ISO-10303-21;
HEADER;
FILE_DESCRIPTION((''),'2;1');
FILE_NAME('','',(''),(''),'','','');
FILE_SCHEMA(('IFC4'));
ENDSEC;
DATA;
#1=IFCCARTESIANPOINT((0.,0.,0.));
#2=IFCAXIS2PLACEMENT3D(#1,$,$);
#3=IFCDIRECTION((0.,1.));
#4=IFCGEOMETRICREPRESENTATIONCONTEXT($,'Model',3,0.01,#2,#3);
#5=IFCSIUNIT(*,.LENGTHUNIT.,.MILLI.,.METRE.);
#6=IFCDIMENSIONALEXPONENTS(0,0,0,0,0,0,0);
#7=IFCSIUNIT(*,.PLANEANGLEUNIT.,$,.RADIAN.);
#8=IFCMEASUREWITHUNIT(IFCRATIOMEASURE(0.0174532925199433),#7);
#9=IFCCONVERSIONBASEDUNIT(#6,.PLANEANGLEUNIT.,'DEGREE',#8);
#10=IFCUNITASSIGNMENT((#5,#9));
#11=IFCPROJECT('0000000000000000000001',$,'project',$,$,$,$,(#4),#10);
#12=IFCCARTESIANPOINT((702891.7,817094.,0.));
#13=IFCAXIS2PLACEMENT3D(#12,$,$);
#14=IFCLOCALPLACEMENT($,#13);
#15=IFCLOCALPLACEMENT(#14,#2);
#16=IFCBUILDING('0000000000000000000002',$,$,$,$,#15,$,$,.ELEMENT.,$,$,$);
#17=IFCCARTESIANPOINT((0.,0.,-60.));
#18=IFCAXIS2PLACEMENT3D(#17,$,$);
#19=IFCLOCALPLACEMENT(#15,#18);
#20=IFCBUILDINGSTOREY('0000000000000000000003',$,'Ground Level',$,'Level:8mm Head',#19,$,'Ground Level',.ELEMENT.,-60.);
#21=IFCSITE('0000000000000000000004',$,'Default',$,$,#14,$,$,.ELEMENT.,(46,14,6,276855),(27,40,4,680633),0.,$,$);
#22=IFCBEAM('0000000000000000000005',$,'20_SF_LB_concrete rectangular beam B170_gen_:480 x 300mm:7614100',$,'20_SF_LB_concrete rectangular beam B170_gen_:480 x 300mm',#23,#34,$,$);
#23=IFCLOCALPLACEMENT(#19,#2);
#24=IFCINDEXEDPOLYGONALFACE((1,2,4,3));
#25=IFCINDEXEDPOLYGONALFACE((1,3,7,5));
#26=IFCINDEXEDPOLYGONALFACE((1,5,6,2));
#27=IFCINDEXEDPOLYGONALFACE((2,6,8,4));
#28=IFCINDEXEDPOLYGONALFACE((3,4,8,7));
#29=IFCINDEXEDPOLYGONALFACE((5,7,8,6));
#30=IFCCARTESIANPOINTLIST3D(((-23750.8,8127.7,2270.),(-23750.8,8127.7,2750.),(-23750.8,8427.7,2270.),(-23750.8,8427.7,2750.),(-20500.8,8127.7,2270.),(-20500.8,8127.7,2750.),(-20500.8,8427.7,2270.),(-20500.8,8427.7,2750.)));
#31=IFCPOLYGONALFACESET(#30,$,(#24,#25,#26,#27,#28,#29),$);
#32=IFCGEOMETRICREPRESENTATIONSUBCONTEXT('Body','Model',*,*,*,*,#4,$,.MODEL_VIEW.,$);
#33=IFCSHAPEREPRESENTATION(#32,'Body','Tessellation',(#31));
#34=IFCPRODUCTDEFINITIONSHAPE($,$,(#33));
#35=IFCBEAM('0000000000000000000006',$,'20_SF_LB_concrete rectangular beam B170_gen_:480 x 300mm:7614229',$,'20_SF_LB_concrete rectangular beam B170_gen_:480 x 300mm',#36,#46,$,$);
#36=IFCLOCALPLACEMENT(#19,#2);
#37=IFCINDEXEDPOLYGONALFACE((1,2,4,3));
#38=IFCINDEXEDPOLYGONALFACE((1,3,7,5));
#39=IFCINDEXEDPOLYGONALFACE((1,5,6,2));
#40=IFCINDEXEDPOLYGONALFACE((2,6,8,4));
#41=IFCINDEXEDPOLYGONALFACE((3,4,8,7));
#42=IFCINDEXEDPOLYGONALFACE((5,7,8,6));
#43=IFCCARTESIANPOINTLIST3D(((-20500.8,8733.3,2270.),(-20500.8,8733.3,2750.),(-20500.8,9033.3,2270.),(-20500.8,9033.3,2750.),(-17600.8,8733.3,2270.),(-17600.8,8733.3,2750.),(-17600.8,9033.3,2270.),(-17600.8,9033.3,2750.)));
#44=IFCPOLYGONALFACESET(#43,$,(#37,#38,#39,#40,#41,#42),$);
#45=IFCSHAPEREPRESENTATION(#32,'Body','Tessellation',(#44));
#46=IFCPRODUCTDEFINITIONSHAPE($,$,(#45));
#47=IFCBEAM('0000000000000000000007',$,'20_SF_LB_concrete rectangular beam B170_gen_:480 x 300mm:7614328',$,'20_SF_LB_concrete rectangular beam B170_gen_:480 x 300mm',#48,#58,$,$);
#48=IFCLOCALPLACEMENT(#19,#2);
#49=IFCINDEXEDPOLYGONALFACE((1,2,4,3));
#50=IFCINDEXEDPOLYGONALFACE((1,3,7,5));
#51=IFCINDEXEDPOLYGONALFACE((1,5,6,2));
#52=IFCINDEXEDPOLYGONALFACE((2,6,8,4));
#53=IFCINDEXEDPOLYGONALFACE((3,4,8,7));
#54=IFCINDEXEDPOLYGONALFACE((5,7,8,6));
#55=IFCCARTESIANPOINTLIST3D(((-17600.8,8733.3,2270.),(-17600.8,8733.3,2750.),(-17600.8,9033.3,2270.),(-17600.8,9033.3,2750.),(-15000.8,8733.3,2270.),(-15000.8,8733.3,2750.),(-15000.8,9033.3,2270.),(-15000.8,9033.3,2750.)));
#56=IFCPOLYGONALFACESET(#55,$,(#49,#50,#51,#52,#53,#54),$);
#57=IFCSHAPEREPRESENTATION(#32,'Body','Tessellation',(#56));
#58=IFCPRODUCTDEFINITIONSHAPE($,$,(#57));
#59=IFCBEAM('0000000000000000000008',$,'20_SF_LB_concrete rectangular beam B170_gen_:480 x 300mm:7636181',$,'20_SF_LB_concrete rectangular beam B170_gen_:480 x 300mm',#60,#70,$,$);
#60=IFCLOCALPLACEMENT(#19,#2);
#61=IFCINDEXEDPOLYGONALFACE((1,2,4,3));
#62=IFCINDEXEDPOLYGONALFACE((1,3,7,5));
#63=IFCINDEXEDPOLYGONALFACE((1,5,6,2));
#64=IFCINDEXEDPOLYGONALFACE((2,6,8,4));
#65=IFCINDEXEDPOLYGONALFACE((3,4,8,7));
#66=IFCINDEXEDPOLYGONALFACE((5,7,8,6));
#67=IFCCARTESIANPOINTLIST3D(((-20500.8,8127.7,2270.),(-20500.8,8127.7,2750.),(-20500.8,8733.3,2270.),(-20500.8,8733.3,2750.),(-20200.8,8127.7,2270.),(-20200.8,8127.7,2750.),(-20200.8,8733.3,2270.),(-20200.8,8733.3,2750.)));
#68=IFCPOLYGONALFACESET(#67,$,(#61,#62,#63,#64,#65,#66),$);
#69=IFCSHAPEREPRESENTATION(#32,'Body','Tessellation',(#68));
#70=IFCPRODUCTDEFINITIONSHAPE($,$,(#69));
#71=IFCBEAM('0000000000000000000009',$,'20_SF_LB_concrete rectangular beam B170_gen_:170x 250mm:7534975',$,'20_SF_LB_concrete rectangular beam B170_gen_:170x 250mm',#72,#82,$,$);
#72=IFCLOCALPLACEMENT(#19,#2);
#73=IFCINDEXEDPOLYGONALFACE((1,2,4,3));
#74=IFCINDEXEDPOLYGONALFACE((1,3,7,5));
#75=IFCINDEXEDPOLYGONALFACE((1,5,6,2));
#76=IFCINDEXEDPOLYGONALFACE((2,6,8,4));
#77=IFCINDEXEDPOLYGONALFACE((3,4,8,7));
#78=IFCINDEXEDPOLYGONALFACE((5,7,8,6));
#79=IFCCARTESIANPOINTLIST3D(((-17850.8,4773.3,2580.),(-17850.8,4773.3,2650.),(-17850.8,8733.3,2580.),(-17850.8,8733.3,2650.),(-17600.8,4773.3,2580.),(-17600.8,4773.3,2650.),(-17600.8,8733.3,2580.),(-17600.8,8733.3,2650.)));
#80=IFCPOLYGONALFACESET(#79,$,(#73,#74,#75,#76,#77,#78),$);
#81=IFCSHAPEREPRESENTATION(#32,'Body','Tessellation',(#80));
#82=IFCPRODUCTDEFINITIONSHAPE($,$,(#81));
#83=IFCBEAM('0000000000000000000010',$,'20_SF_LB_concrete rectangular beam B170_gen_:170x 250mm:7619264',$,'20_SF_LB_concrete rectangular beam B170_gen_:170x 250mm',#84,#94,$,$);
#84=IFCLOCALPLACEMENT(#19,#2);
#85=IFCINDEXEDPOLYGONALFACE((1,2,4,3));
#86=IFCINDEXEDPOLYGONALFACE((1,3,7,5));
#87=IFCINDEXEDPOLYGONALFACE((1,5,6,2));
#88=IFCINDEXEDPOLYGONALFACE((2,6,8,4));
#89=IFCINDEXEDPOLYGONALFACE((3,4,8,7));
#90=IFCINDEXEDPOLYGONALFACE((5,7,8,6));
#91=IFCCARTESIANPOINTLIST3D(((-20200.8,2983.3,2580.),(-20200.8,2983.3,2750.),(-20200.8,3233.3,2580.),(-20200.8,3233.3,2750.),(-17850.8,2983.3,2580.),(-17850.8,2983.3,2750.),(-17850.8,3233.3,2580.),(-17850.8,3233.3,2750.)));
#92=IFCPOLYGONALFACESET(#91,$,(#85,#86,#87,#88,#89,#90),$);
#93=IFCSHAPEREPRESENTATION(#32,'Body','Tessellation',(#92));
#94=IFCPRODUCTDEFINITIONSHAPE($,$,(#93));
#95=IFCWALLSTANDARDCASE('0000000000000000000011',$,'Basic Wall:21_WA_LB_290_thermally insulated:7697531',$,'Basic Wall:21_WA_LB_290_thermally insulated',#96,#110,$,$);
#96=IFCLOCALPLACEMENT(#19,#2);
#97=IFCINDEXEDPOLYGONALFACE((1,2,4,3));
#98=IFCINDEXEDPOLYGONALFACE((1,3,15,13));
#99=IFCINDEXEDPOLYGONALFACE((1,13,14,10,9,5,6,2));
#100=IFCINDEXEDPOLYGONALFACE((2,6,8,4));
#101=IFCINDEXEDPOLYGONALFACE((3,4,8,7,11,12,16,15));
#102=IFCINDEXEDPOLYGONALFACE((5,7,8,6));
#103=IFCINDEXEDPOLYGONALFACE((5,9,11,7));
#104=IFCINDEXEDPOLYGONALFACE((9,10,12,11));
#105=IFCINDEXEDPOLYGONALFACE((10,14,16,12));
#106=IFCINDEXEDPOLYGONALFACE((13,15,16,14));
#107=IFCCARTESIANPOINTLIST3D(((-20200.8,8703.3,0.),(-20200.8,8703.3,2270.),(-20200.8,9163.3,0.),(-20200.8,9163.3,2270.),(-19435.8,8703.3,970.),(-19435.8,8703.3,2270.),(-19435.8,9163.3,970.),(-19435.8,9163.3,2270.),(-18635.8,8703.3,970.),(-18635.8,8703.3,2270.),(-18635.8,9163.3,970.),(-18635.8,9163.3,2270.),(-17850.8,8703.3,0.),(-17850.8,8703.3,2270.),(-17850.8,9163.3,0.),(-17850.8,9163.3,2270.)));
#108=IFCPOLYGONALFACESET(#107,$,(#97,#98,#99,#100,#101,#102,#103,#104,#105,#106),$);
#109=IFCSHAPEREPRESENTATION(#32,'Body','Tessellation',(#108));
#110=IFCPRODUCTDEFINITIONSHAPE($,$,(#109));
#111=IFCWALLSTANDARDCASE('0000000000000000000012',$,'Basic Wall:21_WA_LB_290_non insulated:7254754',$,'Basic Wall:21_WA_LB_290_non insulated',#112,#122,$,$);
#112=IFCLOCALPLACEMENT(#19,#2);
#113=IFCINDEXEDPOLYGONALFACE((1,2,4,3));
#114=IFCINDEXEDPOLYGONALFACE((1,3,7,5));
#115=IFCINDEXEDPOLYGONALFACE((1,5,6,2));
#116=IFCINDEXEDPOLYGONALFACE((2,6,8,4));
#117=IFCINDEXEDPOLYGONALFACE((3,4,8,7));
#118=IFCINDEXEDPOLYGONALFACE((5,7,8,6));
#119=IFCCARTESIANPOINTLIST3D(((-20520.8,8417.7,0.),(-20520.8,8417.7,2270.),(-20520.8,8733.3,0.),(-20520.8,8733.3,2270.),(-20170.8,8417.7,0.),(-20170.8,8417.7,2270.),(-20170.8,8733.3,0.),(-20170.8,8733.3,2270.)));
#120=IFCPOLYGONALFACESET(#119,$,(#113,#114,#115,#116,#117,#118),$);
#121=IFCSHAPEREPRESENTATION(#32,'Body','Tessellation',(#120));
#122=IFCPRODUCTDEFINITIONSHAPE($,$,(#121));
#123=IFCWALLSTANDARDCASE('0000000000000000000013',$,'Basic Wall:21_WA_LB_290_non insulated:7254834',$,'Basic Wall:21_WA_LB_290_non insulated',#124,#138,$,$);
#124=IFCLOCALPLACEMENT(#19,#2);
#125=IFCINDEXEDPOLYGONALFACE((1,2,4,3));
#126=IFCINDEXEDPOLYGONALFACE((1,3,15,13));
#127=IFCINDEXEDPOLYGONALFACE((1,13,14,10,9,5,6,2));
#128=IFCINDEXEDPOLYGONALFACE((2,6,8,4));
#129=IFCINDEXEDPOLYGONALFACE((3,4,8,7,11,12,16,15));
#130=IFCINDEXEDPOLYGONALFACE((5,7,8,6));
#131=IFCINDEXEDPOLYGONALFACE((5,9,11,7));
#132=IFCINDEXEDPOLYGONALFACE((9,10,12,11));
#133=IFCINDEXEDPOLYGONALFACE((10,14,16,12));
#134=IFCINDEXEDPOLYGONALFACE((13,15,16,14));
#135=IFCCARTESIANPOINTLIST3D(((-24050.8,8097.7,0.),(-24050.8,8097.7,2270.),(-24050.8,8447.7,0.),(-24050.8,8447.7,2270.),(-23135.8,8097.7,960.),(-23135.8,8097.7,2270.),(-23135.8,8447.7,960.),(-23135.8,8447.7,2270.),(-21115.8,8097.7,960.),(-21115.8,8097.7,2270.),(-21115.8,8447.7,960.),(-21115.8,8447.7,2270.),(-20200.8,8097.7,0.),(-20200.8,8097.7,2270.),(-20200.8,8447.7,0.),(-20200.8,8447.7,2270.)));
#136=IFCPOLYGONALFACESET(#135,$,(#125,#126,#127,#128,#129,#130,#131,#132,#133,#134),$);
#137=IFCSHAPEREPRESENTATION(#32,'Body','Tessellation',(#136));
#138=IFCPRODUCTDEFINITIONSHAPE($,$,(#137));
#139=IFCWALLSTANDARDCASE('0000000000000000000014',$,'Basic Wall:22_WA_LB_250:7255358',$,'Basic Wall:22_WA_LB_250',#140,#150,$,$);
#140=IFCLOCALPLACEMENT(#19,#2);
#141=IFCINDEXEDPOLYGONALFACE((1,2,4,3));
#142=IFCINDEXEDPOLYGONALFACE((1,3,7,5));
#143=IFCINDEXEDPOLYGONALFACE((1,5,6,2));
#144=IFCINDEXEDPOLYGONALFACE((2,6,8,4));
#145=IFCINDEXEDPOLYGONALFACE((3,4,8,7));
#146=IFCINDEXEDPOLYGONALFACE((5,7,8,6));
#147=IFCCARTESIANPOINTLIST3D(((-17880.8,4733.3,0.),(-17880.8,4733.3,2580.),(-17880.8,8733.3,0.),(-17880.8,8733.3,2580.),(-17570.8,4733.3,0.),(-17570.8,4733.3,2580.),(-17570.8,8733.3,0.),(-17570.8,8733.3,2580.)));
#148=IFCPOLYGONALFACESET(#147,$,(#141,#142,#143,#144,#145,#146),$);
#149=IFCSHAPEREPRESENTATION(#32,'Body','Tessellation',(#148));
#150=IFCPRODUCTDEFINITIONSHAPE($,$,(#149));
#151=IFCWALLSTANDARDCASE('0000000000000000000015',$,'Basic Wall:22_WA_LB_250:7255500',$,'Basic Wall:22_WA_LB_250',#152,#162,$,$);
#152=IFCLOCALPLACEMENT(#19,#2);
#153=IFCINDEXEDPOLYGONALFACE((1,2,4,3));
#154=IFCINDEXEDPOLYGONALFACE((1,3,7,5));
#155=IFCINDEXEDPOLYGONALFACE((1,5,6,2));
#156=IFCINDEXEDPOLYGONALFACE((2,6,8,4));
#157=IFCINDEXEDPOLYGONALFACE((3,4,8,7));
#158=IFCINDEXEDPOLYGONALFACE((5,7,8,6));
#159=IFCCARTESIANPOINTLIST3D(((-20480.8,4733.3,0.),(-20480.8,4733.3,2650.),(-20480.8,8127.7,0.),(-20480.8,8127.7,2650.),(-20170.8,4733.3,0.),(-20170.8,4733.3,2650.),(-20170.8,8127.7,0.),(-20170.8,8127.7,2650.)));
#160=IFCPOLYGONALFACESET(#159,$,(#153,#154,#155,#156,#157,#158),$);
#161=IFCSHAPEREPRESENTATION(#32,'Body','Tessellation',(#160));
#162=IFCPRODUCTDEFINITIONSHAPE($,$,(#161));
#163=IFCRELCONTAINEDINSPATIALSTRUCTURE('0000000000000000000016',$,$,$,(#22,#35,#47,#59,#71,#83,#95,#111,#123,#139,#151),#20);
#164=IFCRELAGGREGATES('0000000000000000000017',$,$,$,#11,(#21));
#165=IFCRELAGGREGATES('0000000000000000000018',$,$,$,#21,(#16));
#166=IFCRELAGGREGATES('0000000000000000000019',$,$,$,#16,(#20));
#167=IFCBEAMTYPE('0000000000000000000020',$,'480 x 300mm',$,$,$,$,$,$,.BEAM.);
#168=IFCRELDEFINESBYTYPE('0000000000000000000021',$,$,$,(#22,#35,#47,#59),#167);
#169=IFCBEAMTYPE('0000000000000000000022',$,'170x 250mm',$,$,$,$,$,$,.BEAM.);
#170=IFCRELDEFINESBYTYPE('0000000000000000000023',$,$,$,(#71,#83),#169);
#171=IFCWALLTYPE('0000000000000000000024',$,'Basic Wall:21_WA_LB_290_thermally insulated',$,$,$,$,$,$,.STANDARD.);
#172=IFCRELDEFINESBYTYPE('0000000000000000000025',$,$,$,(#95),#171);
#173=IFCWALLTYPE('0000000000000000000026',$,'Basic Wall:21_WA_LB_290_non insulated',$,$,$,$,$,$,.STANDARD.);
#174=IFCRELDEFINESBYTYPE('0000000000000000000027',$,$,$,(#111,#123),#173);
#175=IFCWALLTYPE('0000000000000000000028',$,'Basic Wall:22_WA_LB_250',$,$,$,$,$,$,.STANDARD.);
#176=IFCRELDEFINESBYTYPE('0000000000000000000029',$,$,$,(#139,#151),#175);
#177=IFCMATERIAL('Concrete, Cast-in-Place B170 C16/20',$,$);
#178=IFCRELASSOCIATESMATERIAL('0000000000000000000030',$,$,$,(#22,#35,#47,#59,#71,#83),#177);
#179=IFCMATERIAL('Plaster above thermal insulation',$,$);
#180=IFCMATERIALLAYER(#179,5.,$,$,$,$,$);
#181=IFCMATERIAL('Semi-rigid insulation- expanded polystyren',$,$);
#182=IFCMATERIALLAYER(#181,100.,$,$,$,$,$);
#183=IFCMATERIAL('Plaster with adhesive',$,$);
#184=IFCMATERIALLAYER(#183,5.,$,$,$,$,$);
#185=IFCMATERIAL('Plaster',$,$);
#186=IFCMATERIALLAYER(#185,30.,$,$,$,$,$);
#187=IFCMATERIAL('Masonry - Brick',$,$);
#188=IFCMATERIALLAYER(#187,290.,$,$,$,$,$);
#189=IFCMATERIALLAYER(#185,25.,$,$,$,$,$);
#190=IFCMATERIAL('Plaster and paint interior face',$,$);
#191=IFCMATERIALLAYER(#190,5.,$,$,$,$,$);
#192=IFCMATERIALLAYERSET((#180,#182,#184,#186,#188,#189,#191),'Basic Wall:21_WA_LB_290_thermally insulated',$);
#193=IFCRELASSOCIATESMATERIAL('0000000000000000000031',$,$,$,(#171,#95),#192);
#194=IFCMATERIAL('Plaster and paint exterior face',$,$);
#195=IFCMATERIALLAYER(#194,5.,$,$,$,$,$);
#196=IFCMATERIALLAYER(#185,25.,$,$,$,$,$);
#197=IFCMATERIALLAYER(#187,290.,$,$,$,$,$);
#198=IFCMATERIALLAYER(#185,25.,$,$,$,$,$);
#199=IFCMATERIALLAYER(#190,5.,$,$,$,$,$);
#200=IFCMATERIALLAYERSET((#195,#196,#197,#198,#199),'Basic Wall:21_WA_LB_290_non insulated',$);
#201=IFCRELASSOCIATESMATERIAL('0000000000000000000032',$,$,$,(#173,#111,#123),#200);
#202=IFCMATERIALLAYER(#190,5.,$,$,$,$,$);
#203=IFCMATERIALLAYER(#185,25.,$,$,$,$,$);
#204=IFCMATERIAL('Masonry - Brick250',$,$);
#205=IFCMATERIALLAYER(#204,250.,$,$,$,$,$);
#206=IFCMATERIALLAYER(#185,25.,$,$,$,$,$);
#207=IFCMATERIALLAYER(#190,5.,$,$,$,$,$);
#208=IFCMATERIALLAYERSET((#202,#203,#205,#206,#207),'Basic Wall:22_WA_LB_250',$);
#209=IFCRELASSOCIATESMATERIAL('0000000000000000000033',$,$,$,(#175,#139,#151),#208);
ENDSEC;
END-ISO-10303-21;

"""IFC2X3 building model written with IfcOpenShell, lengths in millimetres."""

from ifc_helpers import new_model, entity, si_unit, converted_unit, direction, frame, frame_2d, origin, origin_2d_with_axis, place, context, subcontext, project, spatial, rectangle, extrude, material, layer, layer_set, layer_usage, type_object, element, save


model = new_model("IFC2X3")

# Units and contexts
model_context = context("Model", 3, precision=0.01, world=origin(), true_north=direction((0.0, 1.0)))
body_context = subcontext(model_context, "Body", "Model", "MODEL_VIEW")
ifc_project = project(units=[si_unit("LENGTHUNIT", "METRE", prefix="MILLI"), converted_unit("PLANEANGLEUNIT", "DEGREE", entity("IfcRatioMeasure", 0.0174532925199433), si_unit("PLANEANGLEUNIT", "RADIAN"), dimensions=[0, 0, 0, 0, 0, 0, 0])], contexts=[model_context])

# Site, building, storey
site_placement = place(None, frame((702891.7, 817094.0, 0.0)))
site = spatial("IfcSite", under=ifc_project, at=site_placement, Name="Default", CompositionType="ELEMENT", RefLatitude=(46, 14, 6, 276855), RefLongitude=(27, 40, 4, 680633), RefElevation=0.0)
building_placement = place(site_placement, origin())
building = spatial("IfcBuilding", under=site, at=building_placement, CompositionType="ELEMENT")
storey_placement = place(building_placement, frame((0.0, 0.0, -60.0)))
storey = spatial("IfcBuildingStorey", under=building, at=storey_placement, Name="Ground Level", ObjectType="Level:8mm Head", LongName="Ground Level", CompositionType="ELEMENT", Elevation=-60.0)

# Beams
ifc_material_1 = material(Name="Concrete, Cast-in-Place B170 C16/20")
beam_type_1 = type_object("IfcBeamType", Name="480 x 300mm", PredefinedType="BEAM")
beam_1_placement = place(storey_placement, frame((-23750.8, 8277.7, 0.0)))
element("IfcBeam", 1, at=beam_1_placement, inside=storey, type_object=beam_type_1, material=ifc_material_1, Name="20_SF_LB_concrete rectangular beam B170_gen_:480 x 300mm:7614100", ObjectType="20_SF_LB_concrete rectangular beam B170_gen_:480 x 300mm", context=body_context, shape_type="SweptSolid", body=[
    extrude(rectangle(XDim=480.0, YDim=300.0, at=frame_2d((0.0, 0.0), x_axis=(1.0, 0.0))), frame((0.0, 0.0, 2510.0), z_axis=(1.0, 0.0, 0.0), x_axis=(0.0, 0.0, -1.0)), (0.0, 0.0, 1.0), 3250.0),
])
beam_2_placement = place(storey_placement, frame((-20500.8, 8883.3, 0.0)))
element("IfcBeam", 2, at=beam_2_placement, inside=storey, type_object=beam_type_1, material=ifc_material_1, Name="20_SF_LB_concrete rectangular beam B170_gen_:480 x 300mm:7614229", ObjectType="20_SF_LB_concrete rectangular beam B170_gen_:480 x 300mm", context=body_context, shape_type="SweptSolid", body=[
    extrude(rectangle(XDim=480.0, YDim=300.0, at=frame_2d((0.0, 0.0), x_axis=(1.0, 0.0))), frame((0.0, 0.0, 2510.0), z_axis=(1.0, 0.0, 0.0), x_axis=(0.0, 0.0, -1.0)), (0.0, 0.0, 1.0), 2900.0),
])
beam_3_placement = place(storey_placement, frame((-17600.8, 8883.3, 0.0)))
element("IfcBeam", 3, at=beam_3_placement, inside=storey, type_object=beam_type_1, material=ifc_material_1, Name="20_SF_LB_concrete rectangular beam B170_gen_:480 x 300mm:7614328", ObjectType="20_SF_LB_concrete rectangular beam B170_gen_:480 x 300mm", context=body_context, shape_type="SweptSolid", body=[
    extrude(rectangle(XDim=480.0, YDim=300.0, at=frame_2d((0.0, 0.0), x_axis=(1.0, 0.0))), frame((0.0, 0.0, 2510.0), z_axis=(1.0, 0.0, 0.0), x_axis=(0.0, 0.0, -1.0)), (0.0, 0.0, 1.0), 2600.0),
])
beam_4_placement = place(storey_placement, frame((-20350.8, 8127.7, 0.0), z_axis=(0.0, 0.0, 1.0), x_axis=(0.0, 1.0, 0.0)))
element("IfcBeam", 4, at=beam_4_placement, inside=storey, type_object=beam_type_1, material=ifc_material_1, Name="20_SF_LB_concrete rectangular beam B170_gen_:480 x 300mm:7636181", ObjectType="20_SF_LB_concrete rectangular beam B170_gen_:480 x 300mm", context=body_context, shape_type="SweptSolid", body=[
    extrude(rectangle(XDim=480.0, YDim=300.0, at=frame_2d((0.0, 0.0), x_axis=(1.0, 0.0))), frame((0.0, 0.0, 2510.0), z_axis=(1.0, 0.0, 0.0), x_axis=(0.0, 0.0, -1.0)), (0.0, 0.0, 1.0), 605.6),
])
beam_type_2 = type_object("IfcBeamType", Name="170x 250mm", PredefinedType="BEAM")
beam_5_placement = place(storey_placement, frame((-17725.8, 8733.3, 0.0), z_axis=(0.0, 0.0, 1.0), x_axis=(0.0, -1.0, 0.0)))
element("IfcBeam", 5, at=beam_5_placement, inside=storey, type_object=beam_type_2, material=ifc_material_1, Name="20_SF_LB_concrete rectangular beam B170_gen_:170x 250mm:7534975", ObjectType="20_SF_LB_concrete rectangular beam B170_gen_:170x 250mm", context=body_context, shape_type="SweptSolid", body=[
    extrude(rectangle(XDim=70.0, YDim=250.0, at=frame_2d((0.0, 0.0), x_axis=(1.0, 0.0))), frame((0.0, 0.0, 2615.0), z_axis=(1.0, 0.0, 0.0), x_axis=(0.0, 0.0, -1.0)), (0.0, 0.0, 1.0), 3960.0),
])
beam_6_placement = place(storey_placement, frame((-20200.8, 3108.3, 0.0)))
element("IfcBeam", 6, at=beam_6_placement, inside=storey, type_object=beam_type_2, material=ifc_material_1, Name="20_SF_LB_concrete rectangular beam B170_gen_:170x 250mm:7619264", ObjectType="20_SF_LB_concrete rectangular beam B170_gen_:170x 250mm", context=body_context, shape_type="SweptSolid", body=[
    extrude(rectangle(XDim=170.0, YDim=250.0, at=frame_2d((0.0, 0.0), x_axis=(1.0, 0.0))), frame((0.0, 0.0, 2665.0), z_axis=(1.0, 0.0, 0.0), x_axis=(0.0, 0.0, -1.0)), (0.0, 0.0, 1.0), 2350.0),
])

# Wall, opening
ifc_material_2 = material(Name="Plaster above thermal insulation")
ifc_layer_1 = layer(ifc_material_2, 5.0)
ifc_material_3 = material(Name="Semi-rigid insulation- expanded polystyren")
ifc_layer_2 = layer(ifc_material_3, 100.0)
ifc_material_4 = material(Name="Plaster with adhesive")
ifc_layer_3 = layer(ifc_material_4, 5.0)
ifc_material_5 = material(Name="Plaster")
ifc_layer_4 = layer(ifc_material_5, 30.0)
ifc_material_6 = material(Name="Masonry - Brick")
ifc_layer_5 = layer(ifc_material_6, 290.0)
ifc_layer_6 = layer(ifc_material_5, 25.0)
ifc_material_7 = material(Name="Plaster and paint interior face")
ifc_layer_7 = layer(ifc_material_7, 5.0)
ifc_layer_set_1 = layer_set([ifc_layer_1, ifc_layer_2, ifc_layer_3, ifc_layer_4, ifc_layer_5, ifc_layer_6, ifc_layer_7], Name="Basic Wall:21_WA_LB_290_thermally insulated")
ifc_layer_usage_1 = layer_usage(ifc_layer_set_1, "AXIS2", "POSITIVE", -230.0)
wall_type_1 = type_object("IfcWallType", Name="Basic Wall:21_WA_LB_290_thermally insulated", PredefinedType="STANDARD", material=ifc_layer_set_1)
wall_1_placement = place(storey_placement, frame((-17850.8, 8933.3, 0.0), z_axis=(0.0, 0.0, 1.0), x_axis=(-1.0, 0.0, 0.0)))
wall_1 = element("IfcWallStandardCase", 7, at=wall_1_placement, inside=storey, type_object=wall_type_1, material=ifc_layer_usage_1, Name="Basic Wall:21_WA_LB_290_thermally insulated:7697531", ObjectType="Basic Wall:21_WA_LB_290_thermally insulated", context=body_context, shape_type="SweptSolid", body=[
    extrude(rectangle(XDim=2350.0, YDim=460.0, at=frame_2d((1175.0, 0.0), x_axis=(-1.0, 0.0))), origin(), (0.0, 0.0, 1.0), 2270.0),
])
opening_1_placement = place(wall_1_placement, frame((-17850.8, 8933.3, 0.0), z_axis=(0.0, 0.0, 1.0), x_axis=(-1.0, 0.0, 0.0)))
element("IfcOpeningElement", 8, at=opening_1_placement, cuts=wall_1, ObjectType="Opening", context=body_context, shape_type="SweptSolid", body=[
    extrude(rectangle(XDim=1300.0, YDim=800.0, at=origin_2d_with_axis()), frame((-19035.8, 9163.3, 1620.0), z_axis=(0.0, -1.0, 0.0), x_axis=(0.0, 0.0, -1.0)), (0.0, 0.0, 1.0), 460.0),
])

# Wall
ifc_material_8 = material(Name="Plaster and paint exterior face")
ifc_layer_8 = layer(ifc_material_8, 5.0)
ifc_layer_9 = layer(ifc_material_5, 25.0)
ifc_layer_10 = layer(ifc_material_6, 290.0)
ifc_layer_11 = layer(ifc_material_5, 25.0)
ifc_layer_12 = layer(ifc_material_7, 5.0)
ifc_layer_set_2 = layer_set([ifc_layer_8, ifc_layer_9, ifc_layer_10, ifc_layer_11, ifc_layer_12], Name="Basic Wall:21_WA_LB_290_non insulated")
ifc_layer_usage_2 = layer_usage(ifc_layer_set_2, "AXIS2", "POSITIVE", -175.0)
wall_type_2 = type_object("IfcWallType", Name="Basic Wall:21_WA_LB_290_non insulated", PredefinedType="STANDARD", material=ifc_layer_set_2)
wall_2_placement = place(storey_placement, frame((-20345.8, 8733.3, 0.0), z_axis=(0.0, 0.0, 1.0), x_axis=(0.0, -1.0, 0.0)))
element("IfcWallStandardCase", 9, at=wall_2_placement, inside=storey, type_object=wall_type_2, material=ifc_layer_usage_2, Name="Basic Wall:21_WA_LB_290_non insulated:7254754", ObjectType="Basic Wall:21_WA_LB_290_non insulated", context=body_context, shape_type="SweptSolid", body=[
    extrude(rectangle(XDim=315.6, YDim=350.0, at=frame_2d((157.8, 0.0), x_axis=(-1.0, 0.0))), origin(), (0.0, 0.0, 1.0), 2270.0),
])

# Wall, opening
ifc_layer_usage_3 = layer_usage(ifc_layer_set_2, "AXIS2", "POSITIVE", -175.0)
wall_3_placement = place(storey_placement, frame((-20200.8, 8272.7, 0.0), z_axis=(0.0, 0.0, 1.0), x_axis=(-1.0, 0.0, 0.0)))
wall_3 = element("IfcWallStandardCase", 10, at=wall_3_placement, inside=storey, type_object=wall_type_2, material=ifc_layer_usage_3, Name="Basic Wall:21_WA_LB_290_non insulated:7254834", ObjectType="Basic Wall:21_WA_LB_290_non insulated", context=body_context, shape_type="SweptSolid", body=[
    extrude(rectangle(XDim=3850.0, YDim=350.0, at=frame_2d((1925.0, 0.0), x_axis=(-1.0, 0.0))), origin(), (0.0, 0.0, 1.0), 2270.0),
])
opening_2_placement = place(wall_3_placement, frame((2935.0, 175.0, 960.0)))
element("IfcOpeningElement", 11, at=opening_2_placement, cuts=wall_3, ObjectType="Opening", context=body_context, shape_type="SweptSolid", body=[
    extrude(rectangle(XDim=1320.0, YDim=2020.0, at=frame_2d((660.0, 1010.0), x_axis=(1.0, 0.0))), frame((0.0, 0.0, 0.0), z_axis=(0.0, -1.0, 0.0), x_axis=(0.0, 0.0, 1.0)), (0.0, 0.0, 1.0), 350.0),
])

# Walls
ifc_layer_13 = layer(ifc_material_7, 5.0)
ifc_layer_14 = layer(ifc_material_5, 25.0)
ifc_material_9 = material(Name="Masonry - Brick250")
ifc_layer_15 = layer(ifc_material_9, 250.0)
ifc_layer_16 = layer(ifc_material_5, 25.0)
ifc_layer_17 = layer(ifc_material_7, 5.0)
ifc_layer_set_3 = layer_set([ifc_layer_13, ifc_layer_14, ifc_layer_15, ifc_layer_16, ifc_layer_17], Name="Basic Wall:22_WA_LB_250")
ifc_layer_usage_4 = layer_usage(ifc_layer_set_3, "AXIS2", "NEGATIVE", 155.0)
wall_type_3 = type_object("IfcWallType", Name="Basic Wall:22_WA_LB_250", PredefinedType="STANDARD", material=ifc_layer_set_3)
wall_4_placement = place(storey_placement, frame((-17725.8, 8733.3, 0.0), z_axis=(0.0, 0.0, 1.0), x_axis=(0.0, -1.0, 0.0)))
element("IfcWallStandardCase", 12, at=wall_4_placement, inside=storey, type_object=wall_type_3, material=ifc_layer_usage_4, Name="Basic Wall:22_WA_LB_250:7255358", ObjectType="Basic Wall:22_WA_LB_250", context=body_context, shape_type="SweptSolid", body=[
    extrude(rectangle(XDim=4000.0, YDim=310.0, at=frame_2d((2000.0, 0.0), x_axis=(-1.0, 0.0))), origin(), (0.0, 0.0, 1.0), 2580.0),
])
ifc_layer_usage_5 = layer_usage(ifc_layer_set_3, "AXIS2", "NEGATIVE", 155.0)
wall_5_placement = place(storey_placement, frame((-20325.8, 8127.7, 0.0), z_axis=(0.0, 0.0, 1.0), x_axis=(0.0, -1.0, 0.0)))
element("IfcWallStandardCase", 13, at=wall_5_placement, inside=storey, type_object=wall_type_3, material=ifc_layer_usage_5, Name="Basic Wall:22_WA_LB_250:7255500", ObjectType="Basic Wall:22_WA_LB_250", context=body_context, shape_type="SweptSolid", body=[
    extrude(rectangle(XDim=3394.4, YDim=310.0, at=frame_2d((1697.2, 0.0), x_axis=(-1.0, 0.0))), origin(), (0.0, 0.0, 1.0), 2650.0),
])

save(model, "model.ifc")
